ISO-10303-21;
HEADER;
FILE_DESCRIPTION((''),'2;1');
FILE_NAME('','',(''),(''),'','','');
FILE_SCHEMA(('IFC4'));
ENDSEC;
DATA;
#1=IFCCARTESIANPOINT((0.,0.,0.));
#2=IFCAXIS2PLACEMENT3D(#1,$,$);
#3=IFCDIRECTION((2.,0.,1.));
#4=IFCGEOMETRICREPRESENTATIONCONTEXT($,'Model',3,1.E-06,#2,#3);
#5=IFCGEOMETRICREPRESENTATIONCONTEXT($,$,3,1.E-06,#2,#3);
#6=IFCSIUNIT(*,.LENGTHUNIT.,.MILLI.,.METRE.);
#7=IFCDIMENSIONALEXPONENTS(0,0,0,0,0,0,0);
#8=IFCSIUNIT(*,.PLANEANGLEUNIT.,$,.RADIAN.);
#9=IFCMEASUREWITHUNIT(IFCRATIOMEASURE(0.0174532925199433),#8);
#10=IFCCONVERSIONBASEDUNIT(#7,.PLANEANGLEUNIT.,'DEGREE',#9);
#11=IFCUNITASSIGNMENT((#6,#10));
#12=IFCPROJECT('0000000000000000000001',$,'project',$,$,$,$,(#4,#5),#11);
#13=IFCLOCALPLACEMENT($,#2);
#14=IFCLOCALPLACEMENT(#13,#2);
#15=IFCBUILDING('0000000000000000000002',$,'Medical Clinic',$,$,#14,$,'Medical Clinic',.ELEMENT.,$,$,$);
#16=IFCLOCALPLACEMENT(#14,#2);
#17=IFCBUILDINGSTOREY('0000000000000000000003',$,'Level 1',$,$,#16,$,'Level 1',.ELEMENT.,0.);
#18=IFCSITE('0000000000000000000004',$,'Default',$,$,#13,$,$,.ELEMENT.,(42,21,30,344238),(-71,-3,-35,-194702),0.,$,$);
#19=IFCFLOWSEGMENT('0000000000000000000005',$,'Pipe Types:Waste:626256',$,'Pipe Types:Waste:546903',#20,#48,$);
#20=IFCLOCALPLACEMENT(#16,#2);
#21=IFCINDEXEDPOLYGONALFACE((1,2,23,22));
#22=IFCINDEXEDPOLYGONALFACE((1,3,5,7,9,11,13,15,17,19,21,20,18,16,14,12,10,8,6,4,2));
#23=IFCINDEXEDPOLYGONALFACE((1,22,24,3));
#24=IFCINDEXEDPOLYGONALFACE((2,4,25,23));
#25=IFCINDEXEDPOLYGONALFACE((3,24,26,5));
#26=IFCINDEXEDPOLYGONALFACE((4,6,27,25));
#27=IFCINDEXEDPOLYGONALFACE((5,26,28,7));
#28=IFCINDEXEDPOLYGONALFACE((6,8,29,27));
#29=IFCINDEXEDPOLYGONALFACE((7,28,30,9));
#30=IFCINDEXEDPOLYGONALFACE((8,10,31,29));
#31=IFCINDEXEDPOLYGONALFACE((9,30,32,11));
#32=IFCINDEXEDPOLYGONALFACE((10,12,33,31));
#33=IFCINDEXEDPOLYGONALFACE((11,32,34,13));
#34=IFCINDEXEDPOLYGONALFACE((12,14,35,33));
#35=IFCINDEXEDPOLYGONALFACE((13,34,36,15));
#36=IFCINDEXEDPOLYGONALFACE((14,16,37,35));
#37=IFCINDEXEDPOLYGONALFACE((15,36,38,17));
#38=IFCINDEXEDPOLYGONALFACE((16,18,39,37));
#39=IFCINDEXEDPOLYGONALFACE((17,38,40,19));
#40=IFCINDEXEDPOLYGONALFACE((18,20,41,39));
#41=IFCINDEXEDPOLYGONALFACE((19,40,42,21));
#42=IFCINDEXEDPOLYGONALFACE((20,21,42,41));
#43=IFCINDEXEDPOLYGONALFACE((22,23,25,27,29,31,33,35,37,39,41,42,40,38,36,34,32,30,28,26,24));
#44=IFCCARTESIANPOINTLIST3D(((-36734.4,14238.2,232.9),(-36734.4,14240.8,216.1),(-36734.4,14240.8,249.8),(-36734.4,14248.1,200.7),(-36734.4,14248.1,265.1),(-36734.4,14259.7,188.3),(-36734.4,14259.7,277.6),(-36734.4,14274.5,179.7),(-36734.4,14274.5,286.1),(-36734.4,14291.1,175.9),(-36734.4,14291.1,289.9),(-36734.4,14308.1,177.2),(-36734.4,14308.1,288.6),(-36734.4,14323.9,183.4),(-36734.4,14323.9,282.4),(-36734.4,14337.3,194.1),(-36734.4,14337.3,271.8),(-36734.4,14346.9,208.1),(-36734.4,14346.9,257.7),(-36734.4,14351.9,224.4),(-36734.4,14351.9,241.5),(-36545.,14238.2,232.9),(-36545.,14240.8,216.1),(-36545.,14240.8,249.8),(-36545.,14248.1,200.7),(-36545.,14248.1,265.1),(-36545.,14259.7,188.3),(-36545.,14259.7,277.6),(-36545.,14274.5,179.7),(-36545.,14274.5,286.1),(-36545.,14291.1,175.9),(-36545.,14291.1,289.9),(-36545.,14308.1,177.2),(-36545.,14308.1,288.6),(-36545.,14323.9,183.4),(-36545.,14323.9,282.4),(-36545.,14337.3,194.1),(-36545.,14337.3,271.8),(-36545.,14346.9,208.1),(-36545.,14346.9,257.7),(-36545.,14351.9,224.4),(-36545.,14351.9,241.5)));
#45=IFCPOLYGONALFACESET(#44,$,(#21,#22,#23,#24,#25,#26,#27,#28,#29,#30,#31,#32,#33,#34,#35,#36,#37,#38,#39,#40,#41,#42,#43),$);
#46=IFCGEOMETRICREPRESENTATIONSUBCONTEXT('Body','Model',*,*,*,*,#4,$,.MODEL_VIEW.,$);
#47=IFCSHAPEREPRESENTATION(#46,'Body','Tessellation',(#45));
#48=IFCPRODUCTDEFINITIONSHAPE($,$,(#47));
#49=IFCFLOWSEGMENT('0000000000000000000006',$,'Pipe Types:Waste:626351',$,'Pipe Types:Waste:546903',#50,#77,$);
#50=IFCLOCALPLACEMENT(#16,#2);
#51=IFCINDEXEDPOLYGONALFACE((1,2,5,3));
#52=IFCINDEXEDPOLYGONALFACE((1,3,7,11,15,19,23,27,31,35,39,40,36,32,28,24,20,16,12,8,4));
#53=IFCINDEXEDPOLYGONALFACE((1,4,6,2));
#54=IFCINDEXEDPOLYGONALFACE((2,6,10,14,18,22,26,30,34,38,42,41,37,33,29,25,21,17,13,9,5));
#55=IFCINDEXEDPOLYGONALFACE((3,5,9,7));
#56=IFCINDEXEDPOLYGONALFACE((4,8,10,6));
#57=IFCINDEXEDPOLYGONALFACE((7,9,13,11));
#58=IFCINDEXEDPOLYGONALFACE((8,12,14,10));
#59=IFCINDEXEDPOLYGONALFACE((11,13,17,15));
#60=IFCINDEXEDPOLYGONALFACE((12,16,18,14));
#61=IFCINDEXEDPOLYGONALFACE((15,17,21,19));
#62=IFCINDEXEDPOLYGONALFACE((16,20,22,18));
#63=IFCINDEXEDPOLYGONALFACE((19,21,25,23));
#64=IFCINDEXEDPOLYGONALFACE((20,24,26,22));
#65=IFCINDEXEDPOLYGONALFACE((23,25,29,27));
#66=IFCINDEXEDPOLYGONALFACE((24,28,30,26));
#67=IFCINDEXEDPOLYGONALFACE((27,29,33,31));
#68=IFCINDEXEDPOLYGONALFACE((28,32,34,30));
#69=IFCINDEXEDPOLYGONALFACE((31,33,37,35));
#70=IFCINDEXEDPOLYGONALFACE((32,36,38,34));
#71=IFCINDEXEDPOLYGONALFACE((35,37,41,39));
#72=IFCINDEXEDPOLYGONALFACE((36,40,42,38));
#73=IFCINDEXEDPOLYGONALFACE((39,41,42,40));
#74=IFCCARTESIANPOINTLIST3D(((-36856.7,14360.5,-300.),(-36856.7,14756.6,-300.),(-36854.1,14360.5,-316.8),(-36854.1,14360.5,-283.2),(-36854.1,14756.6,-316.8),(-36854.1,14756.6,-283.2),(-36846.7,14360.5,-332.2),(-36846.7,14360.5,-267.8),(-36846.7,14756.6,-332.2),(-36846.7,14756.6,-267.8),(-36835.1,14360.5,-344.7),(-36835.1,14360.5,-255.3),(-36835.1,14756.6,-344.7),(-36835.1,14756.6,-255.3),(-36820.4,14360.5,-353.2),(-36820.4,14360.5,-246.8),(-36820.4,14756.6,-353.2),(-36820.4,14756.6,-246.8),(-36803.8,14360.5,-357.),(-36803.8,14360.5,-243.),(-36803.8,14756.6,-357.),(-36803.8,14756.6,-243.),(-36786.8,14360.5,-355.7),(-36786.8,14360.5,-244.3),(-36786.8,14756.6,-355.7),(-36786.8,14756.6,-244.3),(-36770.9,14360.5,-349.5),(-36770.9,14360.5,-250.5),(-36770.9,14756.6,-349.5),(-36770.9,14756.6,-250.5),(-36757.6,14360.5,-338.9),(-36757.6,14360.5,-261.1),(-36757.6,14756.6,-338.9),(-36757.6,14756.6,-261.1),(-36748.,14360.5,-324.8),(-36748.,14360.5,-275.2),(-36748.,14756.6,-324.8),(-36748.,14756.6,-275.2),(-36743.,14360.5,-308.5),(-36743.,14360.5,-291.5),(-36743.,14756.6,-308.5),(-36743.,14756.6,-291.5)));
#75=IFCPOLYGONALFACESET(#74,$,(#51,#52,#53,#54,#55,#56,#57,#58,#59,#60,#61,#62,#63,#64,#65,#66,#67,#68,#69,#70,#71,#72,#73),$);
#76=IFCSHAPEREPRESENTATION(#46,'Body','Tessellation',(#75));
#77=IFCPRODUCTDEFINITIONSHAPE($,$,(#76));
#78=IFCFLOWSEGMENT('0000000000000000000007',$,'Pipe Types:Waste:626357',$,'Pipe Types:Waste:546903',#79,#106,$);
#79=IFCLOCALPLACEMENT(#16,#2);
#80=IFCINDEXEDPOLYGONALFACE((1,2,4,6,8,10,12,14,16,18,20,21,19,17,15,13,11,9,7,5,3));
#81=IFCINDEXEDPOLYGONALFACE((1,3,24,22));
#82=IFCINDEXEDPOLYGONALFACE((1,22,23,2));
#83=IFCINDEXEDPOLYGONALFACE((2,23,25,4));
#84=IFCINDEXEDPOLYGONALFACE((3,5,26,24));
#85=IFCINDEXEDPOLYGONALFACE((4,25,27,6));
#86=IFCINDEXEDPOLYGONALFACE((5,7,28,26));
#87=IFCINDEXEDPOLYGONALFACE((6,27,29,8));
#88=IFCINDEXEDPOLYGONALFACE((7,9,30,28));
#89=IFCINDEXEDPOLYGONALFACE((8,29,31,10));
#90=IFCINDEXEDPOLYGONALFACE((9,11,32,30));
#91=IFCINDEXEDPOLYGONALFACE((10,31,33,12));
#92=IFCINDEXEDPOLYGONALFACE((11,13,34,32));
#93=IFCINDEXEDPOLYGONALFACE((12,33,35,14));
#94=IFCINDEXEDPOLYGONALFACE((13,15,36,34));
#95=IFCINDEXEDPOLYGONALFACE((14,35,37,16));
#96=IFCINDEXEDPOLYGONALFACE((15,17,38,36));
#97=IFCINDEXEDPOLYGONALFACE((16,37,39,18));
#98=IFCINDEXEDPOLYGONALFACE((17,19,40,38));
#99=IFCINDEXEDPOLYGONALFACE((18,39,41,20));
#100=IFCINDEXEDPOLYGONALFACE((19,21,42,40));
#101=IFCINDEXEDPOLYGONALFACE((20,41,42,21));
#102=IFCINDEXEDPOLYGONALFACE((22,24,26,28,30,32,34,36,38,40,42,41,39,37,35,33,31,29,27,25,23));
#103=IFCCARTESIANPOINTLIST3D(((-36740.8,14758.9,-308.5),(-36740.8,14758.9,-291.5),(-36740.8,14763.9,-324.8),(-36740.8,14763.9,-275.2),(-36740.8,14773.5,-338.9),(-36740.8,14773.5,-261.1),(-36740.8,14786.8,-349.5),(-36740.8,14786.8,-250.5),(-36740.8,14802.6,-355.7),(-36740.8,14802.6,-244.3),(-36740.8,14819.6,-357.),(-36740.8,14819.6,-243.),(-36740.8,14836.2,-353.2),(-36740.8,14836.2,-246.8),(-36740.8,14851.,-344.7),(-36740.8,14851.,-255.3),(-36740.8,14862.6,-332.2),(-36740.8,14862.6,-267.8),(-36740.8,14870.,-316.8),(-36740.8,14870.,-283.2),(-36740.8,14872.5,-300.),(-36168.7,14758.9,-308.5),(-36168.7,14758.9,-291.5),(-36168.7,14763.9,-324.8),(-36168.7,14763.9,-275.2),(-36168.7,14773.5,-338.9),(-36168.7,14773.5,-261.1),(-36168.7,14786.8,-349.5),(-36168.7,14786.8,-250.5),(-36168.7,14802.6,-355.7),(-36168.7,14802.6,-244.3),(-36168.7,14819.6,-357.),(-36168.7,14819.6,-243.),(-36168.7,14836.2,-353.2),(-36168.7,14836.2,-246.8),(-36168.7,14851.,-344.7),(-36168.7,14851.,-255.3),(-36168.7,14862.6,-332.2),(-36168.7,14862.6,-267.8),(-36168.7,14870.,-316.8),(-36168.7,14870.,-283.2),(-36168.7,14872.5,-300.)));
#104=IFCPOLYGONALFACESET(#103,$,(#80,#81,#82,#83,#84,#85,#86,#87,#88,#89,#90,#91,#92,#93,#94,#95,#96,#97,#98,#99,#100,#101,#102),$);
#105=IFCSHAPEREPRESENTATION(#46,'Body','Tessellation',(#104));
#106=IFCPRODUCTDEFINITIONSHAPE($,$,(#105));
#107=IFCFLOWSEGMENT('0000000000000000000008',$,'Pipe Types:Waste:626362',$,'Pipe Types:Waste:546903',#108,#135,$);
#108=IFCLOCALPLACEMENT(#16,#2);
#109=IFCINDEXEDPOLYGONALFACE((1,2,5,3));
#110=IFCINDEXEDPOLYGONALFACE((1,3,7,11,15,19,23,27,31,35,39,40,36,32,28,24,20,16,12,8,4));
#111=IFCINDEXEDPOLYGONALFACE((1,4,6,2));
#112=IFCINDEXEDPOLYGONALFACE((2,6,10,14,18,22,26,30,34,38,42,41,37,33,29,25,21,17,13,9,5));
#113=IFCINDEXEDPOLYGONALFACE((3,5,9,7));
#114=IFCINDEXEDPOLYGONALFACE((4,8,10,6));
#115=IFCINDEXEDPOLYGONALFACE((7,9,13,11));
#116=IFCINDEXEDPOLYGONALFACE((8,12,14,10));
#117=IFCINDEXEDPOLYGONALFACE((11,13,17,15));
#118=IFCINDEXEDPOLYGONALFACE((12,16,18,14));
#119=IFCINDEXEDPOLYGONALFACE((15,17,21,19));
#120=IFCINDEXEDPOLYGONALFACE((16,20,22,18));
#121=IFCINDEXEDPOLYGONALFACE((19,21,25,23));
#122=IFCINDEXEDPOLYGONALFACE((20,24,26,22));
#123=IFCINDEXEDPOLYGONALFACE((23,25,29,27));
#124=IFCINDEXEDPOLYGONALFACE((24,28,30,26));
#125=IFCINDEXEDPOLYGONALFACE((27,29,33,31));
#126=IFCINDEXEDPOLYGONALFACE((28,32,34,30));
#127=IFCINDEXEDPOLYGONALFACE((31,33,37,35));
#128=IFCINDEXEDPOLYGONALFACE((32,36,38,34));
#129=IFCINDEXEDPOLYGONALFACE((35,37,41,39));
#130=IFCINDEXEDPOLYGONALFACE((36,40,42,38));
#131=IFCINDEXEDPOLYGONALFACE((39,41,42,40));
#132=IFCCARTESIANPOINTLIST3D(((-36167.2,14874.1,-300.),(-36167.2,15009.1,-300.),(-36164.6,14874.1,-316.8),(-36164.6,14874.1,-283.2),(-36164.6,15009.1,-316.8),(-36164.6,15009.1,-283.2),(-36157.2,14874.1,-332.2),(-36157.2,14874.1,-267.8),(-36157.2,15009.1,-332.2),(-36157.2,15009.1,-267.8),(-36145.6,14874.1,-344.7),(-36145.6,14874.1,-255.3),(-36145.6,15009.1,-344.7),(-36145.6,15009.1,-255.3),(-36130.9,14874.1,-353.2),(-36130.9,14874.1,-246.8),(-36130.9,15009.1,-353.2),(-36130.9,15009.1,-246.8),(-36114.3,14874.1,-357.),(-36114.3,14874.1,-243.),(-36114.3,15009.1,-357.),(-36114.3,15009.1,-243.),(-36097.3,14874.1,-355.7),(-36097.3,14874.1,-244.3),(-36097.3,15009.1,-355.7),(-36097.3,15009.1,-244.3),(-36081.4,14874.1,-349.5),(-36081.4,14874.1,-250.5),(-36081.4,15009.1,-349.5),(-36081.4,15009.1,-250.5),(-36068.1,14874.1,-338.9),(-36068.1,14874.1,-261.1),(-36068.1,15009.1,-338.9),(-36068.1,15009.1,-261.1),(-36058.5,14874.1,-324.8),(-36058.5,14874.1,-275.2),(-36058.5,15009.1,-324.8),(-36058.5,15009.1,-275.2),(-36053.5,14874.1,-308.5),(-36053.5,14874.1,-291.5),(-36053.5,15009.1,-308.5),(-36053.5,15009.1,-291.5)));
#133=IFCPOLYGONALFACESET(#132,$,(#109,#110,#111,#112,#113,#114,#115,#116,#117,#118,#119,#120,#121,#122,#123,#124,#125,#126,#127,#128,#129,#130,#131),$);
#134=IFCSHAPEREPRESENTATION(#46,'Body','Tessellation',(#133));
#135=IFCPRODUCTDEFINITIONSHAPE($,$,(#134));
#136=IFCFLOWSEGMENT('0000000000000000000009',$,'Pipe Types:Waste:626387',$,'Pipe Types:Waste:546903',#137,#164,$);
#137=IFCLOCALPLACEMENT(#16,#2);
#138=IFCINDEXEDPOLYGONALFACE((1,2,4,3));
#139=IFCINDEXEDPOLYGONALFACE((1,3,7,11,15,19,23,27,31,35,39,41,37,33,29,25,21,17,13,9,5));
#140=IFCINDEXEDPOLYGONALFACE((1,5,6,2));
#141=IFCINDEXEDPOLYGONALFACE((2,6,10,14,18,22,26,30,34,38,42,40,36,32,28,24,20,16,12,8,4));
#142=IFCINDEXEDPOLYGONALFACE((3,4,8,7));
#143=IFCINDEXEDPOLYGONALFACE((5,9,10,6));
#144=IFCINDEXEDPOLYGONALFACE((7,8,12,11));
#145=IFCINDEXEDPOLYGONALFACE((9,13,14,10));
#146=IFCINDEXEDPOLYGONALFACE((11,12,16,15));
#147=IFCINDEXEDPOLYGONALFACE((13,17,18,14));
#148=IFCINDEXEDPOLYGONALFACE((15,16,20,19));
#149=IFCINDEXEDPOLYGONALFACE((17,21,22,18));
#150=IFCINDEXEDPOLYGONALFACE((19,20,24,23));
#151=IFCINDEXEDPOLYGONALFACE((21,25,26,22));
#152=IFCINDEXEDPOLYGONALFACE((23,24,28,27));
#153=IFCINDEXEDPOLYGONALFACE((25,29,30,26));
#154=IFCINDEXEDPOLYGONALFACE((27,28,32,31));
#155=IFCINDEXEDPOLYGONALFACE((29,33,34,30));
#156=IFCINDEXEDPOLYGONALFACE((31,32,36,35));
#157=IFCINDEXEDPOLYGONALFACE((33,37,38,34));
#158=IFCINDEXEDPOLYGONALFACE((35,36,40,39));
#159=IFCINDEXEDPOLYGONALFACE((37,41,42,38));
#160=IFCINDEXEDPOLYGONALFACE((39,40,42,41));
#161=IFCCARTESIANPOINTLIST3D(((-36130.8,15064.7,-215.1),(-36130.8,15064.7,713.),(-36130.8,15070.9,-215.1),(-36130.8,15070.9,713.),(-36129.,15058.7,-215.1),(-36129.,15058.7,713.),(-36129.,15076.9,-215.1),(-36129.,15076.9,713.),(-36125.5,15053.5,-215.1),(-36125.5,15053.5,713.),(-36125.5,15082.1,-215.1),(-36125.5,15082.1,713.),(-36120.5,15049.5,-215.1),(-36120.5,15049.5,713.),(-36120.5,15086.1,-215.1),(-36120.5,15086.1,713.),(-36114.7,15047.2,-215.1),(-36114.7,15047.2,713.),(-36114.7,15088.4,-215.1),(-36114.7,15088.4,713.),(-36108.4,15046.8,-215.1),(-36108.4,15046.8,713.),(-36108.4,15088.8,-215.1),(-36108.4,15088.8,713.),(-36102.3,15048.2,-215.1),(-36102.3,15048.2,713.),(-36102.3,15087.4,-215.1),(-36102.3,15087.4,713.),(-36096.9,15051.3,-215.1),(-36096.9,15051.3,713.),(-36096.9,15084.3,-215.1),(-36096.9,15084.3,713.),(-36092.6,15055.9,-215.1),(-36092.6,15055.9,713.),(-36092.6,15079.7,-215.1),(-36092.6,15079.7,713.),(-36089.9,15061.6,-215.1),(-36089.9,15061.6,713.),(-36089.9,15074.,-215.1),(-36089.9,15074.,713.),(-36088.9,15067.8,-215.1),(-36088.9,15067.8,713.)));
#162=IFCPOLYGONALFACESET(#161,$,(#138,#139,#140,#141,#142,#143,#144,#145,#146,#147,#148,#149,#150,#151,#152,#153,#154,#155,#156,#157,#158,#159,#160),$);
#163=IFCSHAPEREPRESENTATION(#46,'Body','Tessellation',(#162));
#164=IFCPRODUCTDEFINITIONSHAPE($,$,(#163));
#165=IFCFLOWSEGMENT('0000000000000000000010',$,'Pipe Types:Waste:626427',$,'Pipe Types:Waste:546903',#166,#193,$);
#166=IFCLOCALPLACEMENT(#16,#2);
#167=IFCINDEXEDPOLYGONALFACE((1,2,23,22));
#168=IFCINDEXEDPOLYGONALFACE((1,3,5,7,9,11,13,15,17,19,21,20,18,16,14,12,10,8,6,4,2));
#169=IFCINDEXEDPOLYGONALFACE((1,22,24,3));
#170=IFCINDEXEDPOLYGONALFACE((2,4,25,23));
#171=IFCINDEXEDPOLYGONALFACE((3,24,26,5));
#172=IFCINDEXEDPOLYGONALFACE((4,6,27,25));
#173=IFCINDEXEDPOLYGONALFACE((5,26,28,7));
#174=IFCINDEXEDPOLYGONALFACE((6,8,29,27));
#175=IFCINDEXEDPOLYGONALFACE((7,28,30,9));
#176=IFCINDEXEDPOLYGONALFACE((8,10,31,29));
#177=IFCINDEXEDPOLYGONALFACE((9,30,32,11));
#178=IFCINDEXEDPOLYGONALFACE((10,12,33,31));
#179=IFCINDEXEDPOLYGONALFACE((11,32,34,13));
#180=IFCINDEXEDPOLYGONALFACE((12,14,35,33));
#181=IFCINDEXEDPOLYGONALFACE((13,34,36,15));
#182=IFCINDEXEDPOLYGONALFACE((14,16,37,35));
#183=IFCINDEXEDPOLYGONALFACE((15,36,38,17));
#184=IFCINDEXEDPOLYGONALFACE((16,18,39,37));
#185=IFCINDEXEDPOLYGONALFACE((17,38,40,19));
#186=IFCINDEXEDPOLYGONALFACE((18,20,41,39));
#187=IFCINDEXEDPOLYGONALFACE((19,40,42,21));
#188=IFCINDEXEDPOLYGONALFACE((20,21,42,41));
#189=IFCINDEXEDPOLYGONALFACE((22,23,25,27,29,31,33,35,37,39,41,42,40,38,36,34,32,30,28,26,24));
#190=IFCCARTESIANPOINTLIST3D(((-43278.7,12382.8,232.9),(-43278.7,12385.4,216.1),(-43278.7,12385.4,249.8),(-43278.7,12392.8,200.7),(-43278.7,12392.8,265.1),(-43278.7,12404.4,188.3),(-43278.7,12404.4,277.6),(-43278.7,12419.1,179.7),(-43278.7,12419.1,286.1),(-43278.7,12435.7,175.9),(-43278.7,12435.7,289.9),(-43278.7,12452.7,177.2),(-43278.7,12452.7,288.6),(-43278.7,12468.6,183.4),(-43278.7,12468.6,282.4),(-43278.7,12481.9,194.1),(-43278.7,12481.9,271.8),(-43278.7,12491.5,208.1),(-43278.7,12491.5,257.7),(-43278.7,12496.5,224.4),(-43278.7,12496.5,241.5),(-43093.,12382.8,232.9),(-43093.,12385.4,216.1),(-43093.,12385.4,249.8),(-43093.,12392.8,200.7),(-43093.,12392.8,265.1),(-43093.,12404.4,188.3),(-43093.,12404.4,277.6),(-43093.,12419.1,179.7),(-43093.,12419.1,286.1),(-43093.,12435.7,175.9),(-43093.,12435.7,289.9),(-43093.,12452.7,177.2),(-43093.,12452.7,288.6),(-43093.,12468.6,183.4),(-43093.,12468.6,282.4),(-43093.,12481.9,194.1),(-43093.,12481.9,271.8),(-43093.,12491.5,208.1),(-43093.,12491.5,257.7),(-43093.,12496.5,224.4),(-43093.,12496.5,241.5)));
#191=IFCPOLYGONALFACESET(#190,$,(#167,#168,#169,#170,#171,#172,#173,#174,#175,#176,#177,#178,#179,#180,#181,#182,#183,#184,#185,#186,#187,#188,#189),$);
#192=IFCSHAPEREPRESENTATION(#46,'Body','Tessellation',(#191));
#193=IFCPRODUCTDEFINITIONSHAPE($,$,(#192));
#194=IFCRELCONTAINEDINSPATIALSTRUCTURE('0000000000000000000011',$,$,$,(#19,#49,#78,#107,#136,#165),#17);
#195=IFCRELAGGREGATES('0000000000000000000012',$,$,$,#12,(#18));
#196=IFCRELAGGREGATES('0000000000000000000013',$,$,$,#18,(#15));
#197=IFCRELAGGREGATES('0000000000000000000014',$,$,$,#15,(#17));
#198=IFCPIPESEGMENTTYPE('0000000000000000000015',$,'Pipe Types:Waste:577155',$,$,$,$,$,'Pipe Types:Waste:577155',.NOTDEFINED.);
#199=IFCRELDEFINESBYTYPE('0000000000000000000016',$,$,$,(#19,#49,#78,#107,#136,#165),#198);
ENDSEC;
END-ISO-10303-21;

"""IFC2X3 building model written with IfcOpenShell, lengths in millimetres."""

from ifc_helpers import new_model, entity, si_unit, converted_unit, direction, frame, frame_2d, origin, origin_2d_with_axis, place, context, subcontext, project, spatial, circle, extrude, type_object, element, save


model = new_model("IFC2X3")

# Units and contexts
model_context = context("Model", 3, precision=1e-06, world=origin(), true_north=direction((2.0, 0.0, 1.0)))
context_of_model = context(None, 3, precision=1e-06, world=origin(), true_north=direction((2.0, 0.0, 1.0)))
body_context = subcontext(model_context, "Body", "Model", "MODEL_VIEW")
ifc_project = project(units=[si_unit("LENGTHUNIT", "METRE", prefix="MILLI"), converted_unit("PLANEANGLEUNIT", "DEGREE", entity("IfcRatioMeasure", 0.0174532925199433), si_unit("PLANEANGLEUNIT", "RADIAN"), dimensions=[0, 0, 0, 0, 0, 0, 0])], contexts=[model_context, context_of_model])

# Site, building, storey
site_placement = place(None, origin())
site = spatial("IfcSite", under=ifc_project, at=site_placement, Name="Default", CompositionType="ELEMENT", RefLatitude=(42, 21, 30, 344238), RefLongitude=(-71, -3, -35, -194702), RefElevation=0.0)
building_placement = place(site_placement, origin())
building = spatial("IfcBuilding", under=site, at=building_placement, Name="Medical Clinic", LongName="Medical Clinic", CompositionType="ELEMENT")
storey_placement = place(building_placement, origin())
storey = spatial("IfcBuildingStorey", under=building, at=storey_placement, Name="Level 1", LongName="Level 1", CompositionType="ELEMENT", Elevation=0.0)

# Flow segments
pipe_segment_type = type_object("IfcPipeSegmentType", Name="Pipe Types:Waste:577155", ElementType="Pipe Types:Waste:577155", PredefinedType="NOTDEFINED")
flow_segment_1_placement = place(storey_placement, origin())
element("IfcFlowSegment", 1, at=flow_segment_1_placement, inside=storey, type_object=pipe_segment_type, Name="Pipe Types:Waste:626256", ObjectType="Pipe Types:Waste:546903", context=body_context, shape_type="SweptSolid", body=[
    extrude(circle(Radius=57.1, at=frame_2d((0.0, 0.0), x_axis=(1.0, 0.0))), frame((-36734.4, 14295.4, 232.9), z_axis=(1.0, 0.0, 0.0), x_axis=(0.0, -1.0, 0.0)), (0.0, 0.0, 1.0), 189.4),
])
flow_segment_2_placement = place(storey_placement, origin())
element("IfcFlowSegment", 2, at=flow_segment_2_placement, inside=storey, type_object=pipe_segment_type, Name="Pipe Types:Waste:626351", ObjectType="Pipe Types:Waste:546903", context=body_context, shape_type="SweptSolid", body=[
    extrude(circle(Radius=57.1, at=frame_2d((0.0, 0.0), x_axis=(1.0, 0.0))), frame((-36799.5, 14360.5, -300.0), z_axis=(0.0, 1.0, 0.0), x_axis=(-1.0, 0.0, 0.0)), (0.0, 0.0, 1.0), 396.2),
])
flow_segment_3_placement = place(storey_placement, origin())
element("IfcFlowSegment", 3, at=flow_segment_3_placement, inside=storey, type_object=pipe_segment_type, Name="Pipe Types:Waste:626357", ObjectType="Pipe Types:Waste:546903", context=body_context, shape_type="SweptSolid", body=[
    extrude(circle(Radius=57.1, at=frame_2d((0.0, 0.0), x_axis=(1.0, 0.0))), frame((-36740.8, 14815.4, -300.0), z_axis=(1.0, 0.0, 0.0), x_axis=(0.0, 1.0, 0.0)), (0.0, 0.0, 1.0), 572.0),
])
flow_segment_4_placement = place(storey_placement, origin())
element("IfcFlowSegment", 4, at=flow_segment_4_placement, inside=storey, type_object=pipe_segment_type, Name="Pipe Types:Waste:626362", ObjectType="Pipe Types:Waste:546903", context=body_context, shape_type="SweptSolid", body=[
    extrude(circle(Radius=57.1, at=frame_2d((0.0, 0.0), x_axis=(1.0, 0.0))), frame((-36110.0, 14874.1, -300.0), z_axis=(0.0, 1.0, 0.0), x_axis=(-1.0, 0.0, 0.0)), (0.0, 0.0, 1.0), 135.0),
])
flow_segment_5_placement = place(storey_placement, origin())
element("IfcFlowSegment", 5, at=flow_segment_5_placement, inside=storey, type_object=pipe_segment_type, Name="Pipe Types:Waste:626387", ObjectType="Pipe Types:Waste:546903", context=body_context, shape_type="SweptSolid", body=[
    extrude(circle(Radius=21.1, at=origin_2d_with_axis()), frame((-36110.0, 15067.8, -215.1)), (0.0, 0.0, 1.0), 928.1),
])
flow_segment_6_placement = place(storey_placement, origin())
element("IfcFlowSegment", 6, at=flow_segment_6_placement, inside=storey, type_object=pipe_segment_type, Name="Pipe Types:Waste:626427", ObjectType="Pipe Types:Waste:546903", context=body_context, shape_type="SweptSolid", body=[
    extrude(circle(Radius=57.1, at=frame_2d((0.0, 0.0), x_axis=(1.0, 0.0))), frame((-43278.7, 12440.0, 232.9), z_axis=(1.0, 0.0, 0.0), x_axis=(0.0, -1.0, 0.0)), (0.0, 0.0, 1.0), 185.7),
])

save(model, "model.ifc")
